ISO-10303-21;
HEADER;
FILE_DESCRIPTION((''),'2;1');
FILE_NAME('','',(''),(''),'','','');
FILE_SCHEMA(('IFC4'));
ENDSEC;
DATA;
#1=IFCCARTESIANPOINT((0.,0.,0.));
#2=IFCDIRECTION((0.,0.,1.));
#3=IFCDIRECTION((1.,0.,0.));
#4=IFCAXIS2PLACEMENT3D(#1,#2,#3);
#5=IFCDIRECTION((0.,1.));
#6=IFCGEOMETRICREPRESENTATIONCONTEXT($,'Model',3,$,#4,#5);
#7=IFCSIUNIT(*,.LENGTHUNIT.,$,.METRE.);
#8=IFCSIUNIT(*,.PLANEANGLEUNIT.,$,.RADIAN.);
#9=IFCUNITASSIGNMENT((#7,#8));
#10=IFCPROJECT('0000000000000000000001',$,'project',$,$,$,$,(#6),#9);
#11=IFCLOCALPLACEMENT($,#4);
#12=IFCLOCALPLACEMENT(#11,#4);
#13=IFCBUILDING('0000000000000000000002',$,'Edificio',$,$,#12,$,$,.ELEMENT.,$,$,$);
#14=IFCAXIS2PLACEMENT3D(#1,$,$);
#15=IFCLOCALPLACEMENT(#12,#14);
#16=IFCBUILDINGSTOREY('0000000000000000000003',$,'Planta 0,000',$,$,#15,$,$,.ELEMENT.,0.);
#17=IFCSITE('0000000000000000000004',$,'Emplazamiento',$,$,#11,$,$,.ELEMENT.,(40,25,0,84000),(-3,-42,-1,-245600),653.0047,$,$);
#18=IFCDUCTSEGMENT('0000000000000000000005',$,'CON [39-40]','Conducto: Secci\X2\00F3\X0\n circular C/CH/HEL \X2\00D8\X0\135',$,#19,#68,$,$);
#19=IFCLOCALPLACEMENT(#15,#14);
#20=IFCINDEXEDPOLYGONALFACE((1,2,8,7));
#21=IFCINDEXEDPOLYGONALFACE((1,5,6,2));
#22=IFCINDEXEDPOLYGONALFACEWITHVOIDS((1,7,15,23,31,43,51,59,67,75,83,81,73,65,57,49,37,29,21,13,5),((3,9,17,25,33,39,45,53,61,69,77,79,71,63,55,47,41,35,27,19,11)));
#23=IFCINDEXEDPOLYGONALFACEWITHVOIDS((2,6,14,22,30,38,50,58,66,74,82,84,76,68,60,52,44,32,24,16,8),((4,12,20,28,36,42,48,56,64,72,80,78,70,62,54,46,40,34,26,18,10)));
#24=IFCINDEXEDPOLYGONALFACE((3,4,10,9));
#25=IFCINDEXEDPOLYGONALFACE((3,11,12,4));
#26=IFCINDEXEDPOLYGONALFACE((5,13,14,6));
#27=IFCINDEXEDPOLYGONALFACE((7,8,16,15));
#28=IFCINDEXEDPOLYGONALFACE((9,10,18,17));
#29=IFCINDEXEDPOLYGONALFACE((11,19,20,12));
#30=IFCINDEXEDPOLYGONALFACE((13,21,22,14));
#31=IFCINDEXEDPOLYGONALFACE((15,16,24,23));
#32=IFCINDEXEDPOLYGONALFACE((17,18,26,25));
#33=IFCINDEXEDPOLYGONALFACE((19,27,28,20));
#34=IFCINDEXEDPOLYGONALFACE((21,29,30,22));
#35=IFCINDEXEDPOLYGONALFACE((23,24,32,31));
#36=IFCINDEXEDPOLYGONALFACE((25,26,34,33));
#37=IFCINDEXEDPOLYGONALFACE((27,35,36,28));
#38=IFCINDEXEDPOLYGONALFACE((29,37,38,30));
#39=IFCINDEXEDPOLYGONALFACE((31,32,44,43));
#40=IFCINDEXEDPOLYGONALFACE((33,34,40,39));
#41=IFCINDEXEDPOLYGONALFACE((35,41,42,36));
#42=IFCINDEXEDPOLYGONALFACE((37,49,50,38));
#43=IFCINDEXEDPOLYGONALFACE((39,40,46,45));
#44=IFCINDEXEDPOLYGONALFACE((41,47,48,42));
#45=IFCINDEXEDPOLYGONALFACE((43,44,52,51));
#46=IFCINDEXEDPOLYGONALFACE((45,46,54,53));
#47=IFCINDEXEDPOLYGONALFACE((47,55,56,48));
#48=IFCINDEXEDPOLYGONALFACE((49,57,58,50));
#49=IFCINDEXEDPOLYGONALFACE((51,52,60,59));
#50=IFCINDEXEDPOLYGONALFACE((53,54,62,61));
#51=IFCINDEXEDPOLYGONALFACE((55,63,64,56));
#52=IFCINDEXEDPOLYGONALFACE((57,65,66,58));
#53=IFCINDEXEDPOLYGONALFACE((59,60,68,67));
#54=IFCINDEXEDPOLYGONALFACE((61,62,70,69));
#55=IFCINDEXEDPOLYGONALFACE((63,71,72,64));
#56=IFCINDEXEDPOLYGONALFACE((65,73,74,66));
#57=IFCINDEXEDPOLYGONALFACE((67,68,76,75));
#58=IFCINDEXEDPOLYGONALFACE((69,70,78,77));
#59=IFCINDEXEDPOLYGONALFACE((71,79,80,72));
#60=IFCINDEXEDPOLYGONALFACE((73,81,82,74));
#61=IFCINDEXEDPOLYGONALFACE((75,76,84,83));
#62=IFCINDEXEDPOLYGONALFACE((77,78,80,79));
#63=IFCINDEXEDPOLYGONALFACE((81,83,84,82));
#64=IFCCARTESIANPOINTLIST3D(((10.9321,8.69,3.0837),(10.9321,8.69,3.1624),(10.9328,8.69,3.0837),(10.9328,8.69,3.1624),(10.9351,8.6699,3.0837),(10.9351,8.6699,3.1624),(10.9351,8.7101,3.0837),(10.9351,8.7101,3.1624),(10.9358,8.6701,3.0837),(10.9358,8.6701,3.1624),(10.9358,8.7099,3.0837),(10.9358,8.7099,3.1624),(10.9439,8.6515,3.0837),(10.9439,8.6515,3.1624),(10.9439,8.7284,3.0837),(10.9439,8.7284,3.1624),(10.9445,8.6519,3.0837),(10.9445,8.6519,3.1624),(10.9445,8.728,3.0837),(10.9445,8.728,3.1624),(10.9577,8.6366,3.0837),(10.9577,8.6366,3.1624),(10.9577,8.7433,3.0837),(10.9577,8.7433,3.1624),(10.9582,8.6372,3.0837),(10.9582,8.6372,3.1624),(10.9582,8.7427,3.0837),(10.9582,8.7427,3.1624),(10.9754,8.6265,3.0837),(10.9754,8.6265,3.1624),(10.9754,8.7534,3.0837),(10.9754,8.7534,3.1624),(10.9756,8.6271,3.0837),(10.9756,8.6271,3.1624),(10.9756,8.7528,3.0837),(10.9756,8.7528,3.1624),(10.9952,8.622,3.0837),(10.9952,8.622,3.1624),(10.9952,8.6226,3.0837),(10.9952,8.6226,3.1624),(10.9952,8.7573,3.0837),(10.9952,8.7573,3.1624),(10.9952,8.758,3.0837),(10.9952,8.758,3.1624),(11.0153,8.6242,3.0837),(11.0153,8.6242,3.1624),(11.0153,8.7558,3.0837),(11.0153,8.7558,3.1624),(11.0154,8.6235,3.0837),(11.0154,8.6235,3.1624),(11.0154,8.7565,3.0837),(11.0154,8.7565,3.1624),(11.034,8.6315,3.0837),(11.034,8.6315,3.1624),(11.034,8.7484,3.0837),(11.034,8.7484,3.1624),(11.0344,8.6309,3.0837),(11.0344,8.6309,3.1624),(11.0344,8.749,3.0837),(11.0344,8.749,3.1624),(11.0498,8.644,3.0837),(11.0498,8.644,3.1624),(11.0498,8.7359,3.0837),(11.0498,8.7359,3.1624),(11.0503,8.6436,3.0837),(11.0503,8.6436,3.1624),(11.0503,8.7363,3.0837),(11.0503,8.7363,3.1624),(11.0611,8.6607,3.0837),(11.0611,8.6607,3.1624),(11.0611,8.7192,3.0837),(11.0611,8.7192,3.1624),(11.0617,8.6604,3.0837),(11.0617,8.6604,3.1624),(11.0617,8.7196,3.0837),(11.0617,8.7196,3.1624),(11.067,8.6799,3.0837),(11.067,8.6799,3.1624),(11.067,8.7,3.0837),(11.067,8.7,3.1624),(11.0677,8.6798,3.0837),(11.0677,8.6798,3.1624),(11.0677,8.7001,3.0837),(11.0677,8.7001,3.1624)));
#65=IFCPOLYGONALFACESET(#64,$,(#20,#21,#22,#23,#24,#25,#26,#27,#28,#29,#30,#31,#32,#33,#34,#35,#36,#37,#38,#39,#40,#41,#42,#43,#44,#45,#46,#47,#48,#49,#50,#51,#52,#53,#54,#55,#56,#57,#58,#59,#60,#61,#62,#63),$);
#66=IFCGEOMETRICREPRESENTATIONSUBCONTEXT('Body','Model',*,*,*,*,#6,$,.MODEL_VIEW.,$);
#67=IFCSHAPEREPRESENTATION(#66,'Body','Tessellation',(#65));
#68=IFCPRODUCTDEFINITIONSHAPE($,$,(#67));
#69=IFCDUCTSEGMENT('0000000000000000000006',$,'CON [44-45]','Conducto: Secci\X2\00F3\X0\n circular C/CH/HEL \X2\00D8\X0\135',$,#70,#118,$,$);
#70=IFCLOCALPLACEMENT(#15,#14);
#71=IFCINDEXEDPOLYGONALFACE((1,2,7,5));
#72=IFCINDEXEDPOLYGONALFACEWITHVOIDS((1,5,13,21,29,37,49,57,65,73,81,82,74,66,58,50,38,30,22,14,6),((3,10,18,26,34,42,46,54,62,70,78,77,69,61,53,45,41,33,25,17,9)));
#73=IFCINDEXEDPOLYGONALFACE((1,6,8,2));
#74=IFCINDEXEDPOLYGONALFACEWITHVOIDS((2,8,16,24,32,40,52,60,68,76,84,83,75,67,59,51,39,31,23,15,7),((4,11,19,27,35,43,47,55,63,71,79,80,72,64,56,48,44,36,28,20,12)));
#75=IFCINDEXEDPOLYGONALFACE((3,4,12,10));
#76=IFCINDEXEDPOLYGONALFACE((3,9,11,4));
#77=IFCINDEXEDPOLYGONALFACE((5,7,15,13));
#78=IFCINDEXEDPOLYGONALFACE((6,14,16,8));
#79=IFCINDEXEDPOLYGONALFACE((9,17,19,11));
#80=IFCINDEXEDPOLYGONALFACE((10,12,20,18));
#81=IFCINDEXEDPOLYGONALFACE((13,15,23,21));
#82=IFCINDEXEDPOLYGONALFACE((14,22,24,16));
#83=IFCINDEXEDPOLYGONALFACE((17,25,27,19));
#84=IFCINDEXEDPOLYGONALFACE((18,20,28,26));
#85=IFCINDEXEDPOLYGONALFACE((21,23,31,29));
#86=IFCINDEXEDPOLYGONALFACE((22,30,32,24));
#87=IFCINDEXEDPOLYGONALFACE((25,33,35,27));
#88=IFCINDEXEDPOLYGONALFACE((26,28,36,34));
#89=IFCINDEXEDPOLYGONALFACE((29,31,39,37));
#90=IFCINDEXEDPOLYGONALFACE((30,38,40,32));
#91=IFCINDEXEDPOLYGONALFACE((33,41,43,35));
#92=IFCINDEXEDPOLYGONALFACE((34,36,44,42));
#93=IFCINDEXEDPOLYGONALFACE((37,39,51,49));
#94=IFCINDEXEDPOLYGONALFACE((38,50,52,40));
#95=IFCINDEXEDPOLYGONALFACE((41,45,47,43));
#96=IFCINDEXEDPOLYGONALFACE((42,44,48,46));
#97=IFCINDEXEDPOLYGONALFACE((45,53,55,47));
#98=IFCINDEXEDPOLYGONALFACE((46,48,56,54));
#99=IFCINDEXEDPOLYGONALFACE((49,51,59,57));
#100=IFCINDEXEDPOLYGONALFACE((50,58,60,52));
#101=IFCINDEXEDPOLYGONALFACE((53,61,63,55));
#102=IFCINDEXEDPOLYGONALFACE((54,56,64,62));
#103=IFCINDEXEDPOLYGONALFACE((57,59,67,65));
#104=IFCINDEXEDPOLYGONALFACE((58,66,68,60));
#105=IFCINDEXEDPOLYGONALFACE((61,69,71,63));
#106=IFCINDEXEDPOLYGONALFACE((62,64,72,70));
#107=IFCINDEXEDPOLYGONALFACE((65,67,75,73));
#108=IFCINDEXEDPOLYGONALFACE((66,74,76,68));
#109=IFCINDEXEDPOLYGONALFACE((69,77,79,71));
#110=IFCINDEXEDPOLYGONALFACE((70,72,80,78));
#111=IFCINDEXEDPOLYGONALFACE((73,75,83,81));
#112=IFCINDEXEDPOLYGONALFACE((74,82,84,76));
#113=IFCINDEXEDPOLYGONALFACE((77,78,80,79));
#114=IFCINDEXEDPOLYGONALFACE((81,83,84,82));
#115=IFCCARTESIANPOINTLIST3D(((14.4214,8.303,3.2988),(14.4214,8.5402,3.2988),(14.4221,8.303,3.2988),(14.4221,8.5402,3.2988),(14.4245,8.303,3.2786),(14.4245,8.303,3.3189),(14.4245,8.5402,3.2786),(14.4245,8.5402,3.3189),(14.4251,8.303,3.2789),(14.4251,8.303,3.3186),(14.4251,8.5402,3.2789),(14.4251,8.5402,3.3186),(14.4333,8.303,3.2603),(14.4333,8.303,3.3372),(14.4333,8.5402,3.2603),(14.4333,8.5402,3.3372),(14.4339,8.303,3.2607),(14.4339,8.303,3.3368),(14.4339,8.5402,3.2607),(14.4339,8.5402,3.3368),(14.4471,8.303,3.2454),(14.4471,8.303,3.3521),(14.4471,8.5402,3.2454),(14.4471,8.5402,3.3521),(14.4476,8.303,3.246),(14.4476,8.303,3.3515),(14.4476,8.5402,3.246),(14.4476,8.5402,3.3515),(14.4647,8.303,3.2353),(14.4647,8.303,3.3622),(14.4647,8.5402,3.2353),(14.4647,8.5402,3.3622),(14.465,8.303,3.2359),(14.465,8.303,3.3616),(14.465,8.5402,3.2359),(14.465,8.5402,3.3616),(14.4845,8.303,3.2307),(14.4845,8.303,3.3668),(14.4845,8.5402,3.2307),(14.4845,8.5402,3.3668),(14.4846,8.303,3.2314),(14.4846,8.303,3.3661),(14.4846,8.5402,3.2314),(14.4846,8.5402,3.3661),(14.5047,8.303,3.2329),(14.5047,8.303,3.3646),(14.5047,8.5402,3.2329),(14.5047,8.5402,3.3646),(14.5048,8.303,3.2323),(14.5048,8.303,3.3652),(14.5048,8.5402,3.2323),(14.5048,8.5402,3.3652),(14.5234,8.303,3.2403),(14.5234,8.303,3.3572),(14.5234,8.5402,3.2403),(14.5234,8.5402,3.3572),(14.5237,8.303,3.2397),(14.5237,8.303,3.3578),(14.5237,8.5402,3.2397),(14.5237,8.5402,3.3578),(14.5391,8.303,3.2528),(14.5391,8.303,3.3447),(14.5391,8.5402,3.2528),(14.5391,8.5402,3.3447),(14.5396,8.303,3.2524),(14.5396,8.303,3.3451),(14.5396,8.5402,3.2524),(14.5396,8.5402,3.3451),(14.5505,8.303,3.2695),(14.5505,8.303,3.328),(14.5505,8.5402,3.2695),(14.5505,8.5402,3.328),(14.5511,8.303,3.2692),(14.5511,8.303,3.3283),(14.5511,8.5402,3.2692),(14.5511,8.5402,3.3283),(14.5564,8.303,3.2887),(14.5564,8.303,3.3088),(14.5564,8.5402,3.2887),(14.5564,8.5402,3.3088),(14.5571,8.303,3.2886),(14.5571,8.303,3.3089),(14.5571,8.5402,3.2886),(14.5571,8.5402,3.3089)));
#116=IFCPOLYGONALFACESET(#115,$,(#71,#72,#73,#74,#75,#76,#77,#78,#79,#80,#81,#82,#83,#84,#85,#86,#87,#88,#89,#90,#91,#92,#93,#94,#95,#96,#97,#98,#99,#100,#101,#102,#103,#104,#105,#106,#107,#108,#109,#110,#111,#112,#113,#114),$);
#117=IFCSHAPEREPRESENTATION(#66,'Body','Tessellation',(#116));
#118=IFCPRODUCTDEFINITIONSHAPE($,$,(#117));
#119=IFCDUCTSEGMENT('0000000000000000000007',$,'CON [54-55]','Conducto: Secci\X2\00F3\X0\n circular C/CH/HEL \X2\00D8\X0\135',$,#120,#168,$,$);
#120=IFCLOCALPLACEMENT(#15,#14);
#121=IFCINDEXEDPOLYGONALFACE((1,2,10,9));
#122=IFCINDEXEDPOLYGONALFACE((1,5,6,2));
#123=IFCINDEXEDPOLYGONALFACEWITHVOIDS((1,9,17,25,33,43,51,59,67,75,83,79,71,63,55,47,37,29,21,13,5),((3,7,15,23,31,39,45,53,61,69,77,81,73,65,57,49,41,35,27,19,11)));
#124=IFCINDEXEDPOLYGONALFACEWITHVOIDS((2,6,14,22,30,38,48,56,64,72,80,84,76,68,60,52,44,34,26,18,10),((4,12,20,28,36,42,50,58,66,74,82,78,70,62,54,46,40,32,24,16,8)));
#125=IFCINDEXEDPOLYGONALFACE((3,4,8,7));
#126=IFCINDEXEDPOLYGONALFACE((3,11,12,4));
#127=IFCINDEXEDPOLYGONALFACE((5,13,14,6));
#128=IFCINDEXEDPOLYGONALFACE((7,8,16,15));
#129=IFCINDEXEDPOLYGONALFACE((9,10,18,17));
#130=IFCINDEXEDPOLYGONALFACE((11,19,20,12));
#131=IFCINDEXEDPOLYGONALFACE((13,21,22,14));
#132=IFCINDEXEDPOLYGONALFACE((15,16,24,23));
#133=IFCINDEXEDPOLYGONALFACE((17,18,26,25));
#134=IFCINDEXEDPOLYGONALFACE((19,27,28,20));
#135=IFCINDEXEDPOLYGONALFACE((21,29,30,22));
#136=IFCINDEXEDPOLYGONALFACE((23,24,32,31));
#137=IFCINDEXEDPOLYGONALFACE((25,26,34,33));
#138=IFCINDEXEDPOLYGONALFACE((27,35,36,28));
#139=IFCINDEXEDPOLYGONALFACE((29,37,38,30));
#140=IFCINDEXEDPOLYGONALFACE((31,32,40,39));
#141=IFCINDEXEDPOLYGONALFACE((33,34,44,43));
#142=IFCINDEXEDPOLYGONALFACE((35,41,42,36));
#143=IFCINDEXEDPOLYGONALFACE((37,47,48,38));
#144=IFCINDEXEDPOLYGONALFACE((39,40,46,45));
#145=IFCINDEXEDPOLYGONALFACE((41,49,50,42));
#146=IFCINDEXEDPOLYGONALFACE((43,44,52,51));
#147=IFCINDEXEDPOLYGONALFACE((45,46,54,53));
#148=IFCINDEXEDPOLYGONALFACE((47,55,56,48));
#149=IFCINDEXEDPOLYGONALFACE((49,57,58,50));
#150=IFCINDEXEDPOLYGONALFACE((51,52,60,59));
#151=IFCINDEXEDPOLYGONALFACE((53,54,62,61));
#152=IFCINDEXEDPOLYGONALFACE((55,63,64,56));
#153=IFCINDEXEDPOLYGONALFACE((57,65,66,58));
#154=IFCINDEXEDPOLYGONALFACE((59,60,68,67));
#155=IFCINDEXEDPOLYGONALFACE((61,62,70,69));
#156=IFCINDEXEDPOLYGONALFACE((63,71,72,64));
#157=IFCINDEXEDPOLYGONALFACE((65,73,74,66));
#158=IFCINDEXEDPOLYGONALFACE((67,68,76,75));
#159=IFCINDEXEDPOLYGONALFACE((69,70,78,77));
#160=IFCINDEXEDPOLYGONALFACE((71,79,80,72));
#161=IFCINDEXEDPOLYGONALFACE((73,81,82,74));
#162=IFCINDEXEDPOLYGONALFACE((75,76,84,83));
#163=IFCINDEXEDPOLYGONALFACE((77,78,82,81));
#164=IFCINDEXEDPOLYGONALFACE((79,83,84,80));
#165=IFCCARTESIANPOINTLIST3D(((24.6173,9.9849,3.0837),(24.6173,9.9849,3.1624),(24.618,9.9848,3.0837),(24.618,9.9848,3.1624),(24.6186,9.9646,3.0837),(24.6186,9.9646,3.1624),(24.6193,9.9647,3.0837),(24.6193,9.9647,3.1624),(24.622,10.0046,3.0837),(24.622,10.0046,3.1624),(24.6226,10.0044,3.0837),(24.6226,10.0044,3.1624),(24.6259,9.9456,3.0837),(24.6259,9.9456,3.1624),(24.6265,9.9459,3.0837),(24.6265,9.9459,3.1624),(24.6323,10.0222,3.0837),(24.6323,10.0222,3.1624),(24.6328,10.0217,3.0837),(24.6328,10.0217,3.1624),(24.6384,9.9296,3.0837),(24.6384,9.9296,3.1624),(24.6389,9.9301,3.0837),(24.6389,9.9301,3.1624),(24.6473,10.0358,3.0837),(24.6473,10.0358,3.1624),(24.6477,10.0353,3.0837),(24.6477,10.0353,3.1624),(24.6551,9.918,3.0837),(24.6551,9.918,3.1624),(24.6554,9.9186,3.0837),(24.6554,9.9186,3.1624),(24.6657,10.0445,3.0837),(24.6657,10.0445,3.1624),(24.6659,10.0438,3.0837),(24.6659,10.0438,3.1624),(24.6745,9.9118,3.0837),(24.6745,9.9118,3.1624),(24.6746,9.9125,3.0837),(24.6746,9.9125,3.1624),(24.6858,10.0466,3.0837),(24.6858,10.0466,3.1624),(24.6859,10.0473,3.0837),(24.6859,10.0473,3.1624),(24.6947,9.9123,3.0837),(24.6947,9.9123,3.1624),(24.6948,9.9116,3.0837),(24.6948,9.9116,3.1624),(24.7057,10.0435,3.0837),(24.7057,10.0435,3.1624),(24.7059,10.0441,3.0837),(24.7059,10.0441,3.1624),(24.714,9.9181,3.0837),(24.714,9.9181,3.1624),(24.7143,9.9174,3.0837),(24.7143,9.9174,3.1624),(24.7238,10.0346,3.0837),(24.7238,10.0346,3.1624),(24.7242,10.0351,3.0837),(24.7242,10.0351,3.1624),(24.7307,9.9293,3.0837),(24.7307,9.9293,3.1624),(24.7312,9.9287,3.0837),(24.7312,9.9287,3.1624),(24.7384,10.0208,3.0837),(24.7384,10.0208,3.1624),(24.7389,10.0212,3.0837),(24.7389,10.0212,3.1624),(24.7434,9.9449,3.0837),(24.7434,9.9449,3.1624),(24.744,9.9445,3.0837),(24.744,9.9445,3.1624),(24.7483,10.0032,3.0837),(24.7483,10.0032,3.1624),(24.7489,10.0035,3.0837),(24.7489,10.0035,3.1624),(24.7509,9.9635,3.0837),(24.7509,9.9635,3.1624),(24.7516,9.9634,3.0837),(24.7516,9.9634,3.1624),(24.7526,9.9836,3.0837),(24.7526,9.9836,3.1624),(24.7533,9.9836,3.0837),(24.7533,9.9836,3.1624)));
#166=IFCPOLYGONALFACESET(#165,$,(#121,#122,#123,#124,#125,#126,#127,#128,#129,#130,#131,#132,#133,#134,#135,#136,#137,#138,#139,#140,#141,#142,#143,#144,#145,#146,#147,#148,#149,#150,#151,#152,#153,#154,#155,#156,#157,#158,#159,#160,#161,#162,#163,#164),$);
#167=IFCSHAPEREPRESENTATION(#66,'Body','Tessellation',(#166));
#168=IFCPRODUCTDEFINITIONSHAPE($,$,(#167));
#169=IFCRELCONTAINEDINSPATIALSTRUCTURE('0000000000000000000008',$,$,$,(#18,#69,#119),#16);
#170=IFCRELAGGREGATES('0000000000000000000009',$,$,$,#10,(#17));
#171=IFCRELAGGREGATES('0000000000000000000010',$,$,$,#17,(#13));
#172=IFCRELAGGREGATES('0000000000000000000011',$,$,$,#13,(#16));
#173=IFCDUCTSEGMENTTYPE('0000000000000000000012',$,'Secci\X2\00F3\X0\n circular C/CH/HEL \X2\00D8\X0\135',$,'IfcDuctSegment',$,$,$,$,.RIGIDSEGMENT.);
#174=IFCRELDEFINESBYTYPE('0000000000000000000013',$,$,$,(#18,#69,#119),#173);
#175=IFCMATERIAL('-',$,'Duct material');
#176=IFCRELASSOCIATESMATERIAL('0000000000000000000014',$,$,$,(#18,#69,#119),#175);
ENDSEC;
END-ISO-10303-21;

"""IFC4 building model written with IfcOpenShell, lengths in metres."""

from ifc_helpers import new_model, si_unit, direction, frame, origin, origin_with_axes, origin_2d_with_axis, place, context, subcontext, project, spatial, hollow_circle, extrude, material, type_object, element, save


model = new_model("IFC4")

# Units and contexts
model_context = context("Model", 3, world=origin_with_axes(), true_north=direction((0.0, 1.0)))
body_context = subcontext(model_context, "Body", "Model", "MODEL_VIEW")
ifc_project = project(units=[si_unit("LENGTHUNIT", "METRE"), si_unit("PLANEANGLEUNIT", "RADIAN")], contexts=[model_context])

# Site, building, storey
site_placement = place(None, origin_with_axes())
site = spatial("IfcSite", under=ifc_project, at=site_placement, Name="Emplazamiento", CompositionType="ELEMENT", RefLatitude=(40, 25, 0, 84000), RefLongitude=(-3, -42, -1, -245600), RefElevation=653.0047)
building_placement = place(site_placement, origin_with_axes())
building = spatial("IfcBuilding", under=site, at=building_placement, Name="Edificio", CompositionType="ELEMENT")
storey_placement = place(building_placement, origin())
storey = spatial("IfcBuildingStorey", under=building, at=storey_placement, Name="Planta 0,000", CompositionType="ELEMENT", Elevation=0.0)

# Shared definitions
ifc_material_1 = material(Name="-", Category="Duct material")

# Duct segments
duct_segment_type_1 = type_object("IfcDuctSegmentType", Name="Sección circular C/CH/HEL Ø135", ApplicableOccurrence="IfcDuctSegment", PredefinedType="RIGIDSEGMENT")
duct_segment_1_placement = place(storey_placement, origin_with_axes())
element("IfcDuctSegment", 1, at=duct_segment_1_placement, inside=storey, type_object=duct_segment_type_1, material=ifc_material_1, Name="CON [39-40]", Description="Conducto: Sección circular C/CH/HEL Ø135", context=body_context, shape_type="SweptSolid", body=[
    extrude(hollow_circle(Radius=0.0682, WallThickness=0.0007, at=origin_2d_with_axis()), frame((11.0003, 8.69, 3.1624), z_axis=(0.0, 0.0, -1.0), x_axis=(-1.0, 0.0, 0.0)), (0.0, 0.0, 1.0), 0.0786),
])
duct_segment_2_placement = place(storey_placement, origin_with_axes())
element("IfcDuctSegment", 2, at=duct_segment_2_placement, inside=storey, type_object=duct_segment_type_1, material=ifc_material_1, Name="CON [44-45]", Description="Conducto: Sección circular C/CH/HEL Ø135", context=body_context, shape_type="SweptSolid", body=[
    extrude(hollow_circle(Radius=0.0682, WallThickness=0.0007, at=origin_2d_with_axis()), frame((14.4896, 8.303, 3.2988), z_axis=(0.0, 1.0, 0.0), x_axis=(-1.0, 0.0, 0.0)), (0.0, 0.0, 1.0), 0.2372),
])
duct_segment_3_placement = place(storey_placement, origin_with_axes())
element("IfcDuctSegment", 3, at=duct_segment_3_placement, inside=storey, type_object=duct_segment_type_1, material=ifc_material_1, Name="CON [54-55]", Description="Conducto: Sección circular C/CH/HEL Ø135", context=body_context, shape_type="SweptSolid", body=[
    extrude(hollow_circle(Radius=0.0682, WallThickness=0.0007, at=origin_2d_with_axis()), frame((24.6852, 9.9791, 3.1624), z_axis=(0.0, 0.0, -1.0), x_axis=(0.009091, 0.999959, 0.0)), (0.0, 0.0, 1.0), 0.0786),
])

save(model, "model.ifc")
